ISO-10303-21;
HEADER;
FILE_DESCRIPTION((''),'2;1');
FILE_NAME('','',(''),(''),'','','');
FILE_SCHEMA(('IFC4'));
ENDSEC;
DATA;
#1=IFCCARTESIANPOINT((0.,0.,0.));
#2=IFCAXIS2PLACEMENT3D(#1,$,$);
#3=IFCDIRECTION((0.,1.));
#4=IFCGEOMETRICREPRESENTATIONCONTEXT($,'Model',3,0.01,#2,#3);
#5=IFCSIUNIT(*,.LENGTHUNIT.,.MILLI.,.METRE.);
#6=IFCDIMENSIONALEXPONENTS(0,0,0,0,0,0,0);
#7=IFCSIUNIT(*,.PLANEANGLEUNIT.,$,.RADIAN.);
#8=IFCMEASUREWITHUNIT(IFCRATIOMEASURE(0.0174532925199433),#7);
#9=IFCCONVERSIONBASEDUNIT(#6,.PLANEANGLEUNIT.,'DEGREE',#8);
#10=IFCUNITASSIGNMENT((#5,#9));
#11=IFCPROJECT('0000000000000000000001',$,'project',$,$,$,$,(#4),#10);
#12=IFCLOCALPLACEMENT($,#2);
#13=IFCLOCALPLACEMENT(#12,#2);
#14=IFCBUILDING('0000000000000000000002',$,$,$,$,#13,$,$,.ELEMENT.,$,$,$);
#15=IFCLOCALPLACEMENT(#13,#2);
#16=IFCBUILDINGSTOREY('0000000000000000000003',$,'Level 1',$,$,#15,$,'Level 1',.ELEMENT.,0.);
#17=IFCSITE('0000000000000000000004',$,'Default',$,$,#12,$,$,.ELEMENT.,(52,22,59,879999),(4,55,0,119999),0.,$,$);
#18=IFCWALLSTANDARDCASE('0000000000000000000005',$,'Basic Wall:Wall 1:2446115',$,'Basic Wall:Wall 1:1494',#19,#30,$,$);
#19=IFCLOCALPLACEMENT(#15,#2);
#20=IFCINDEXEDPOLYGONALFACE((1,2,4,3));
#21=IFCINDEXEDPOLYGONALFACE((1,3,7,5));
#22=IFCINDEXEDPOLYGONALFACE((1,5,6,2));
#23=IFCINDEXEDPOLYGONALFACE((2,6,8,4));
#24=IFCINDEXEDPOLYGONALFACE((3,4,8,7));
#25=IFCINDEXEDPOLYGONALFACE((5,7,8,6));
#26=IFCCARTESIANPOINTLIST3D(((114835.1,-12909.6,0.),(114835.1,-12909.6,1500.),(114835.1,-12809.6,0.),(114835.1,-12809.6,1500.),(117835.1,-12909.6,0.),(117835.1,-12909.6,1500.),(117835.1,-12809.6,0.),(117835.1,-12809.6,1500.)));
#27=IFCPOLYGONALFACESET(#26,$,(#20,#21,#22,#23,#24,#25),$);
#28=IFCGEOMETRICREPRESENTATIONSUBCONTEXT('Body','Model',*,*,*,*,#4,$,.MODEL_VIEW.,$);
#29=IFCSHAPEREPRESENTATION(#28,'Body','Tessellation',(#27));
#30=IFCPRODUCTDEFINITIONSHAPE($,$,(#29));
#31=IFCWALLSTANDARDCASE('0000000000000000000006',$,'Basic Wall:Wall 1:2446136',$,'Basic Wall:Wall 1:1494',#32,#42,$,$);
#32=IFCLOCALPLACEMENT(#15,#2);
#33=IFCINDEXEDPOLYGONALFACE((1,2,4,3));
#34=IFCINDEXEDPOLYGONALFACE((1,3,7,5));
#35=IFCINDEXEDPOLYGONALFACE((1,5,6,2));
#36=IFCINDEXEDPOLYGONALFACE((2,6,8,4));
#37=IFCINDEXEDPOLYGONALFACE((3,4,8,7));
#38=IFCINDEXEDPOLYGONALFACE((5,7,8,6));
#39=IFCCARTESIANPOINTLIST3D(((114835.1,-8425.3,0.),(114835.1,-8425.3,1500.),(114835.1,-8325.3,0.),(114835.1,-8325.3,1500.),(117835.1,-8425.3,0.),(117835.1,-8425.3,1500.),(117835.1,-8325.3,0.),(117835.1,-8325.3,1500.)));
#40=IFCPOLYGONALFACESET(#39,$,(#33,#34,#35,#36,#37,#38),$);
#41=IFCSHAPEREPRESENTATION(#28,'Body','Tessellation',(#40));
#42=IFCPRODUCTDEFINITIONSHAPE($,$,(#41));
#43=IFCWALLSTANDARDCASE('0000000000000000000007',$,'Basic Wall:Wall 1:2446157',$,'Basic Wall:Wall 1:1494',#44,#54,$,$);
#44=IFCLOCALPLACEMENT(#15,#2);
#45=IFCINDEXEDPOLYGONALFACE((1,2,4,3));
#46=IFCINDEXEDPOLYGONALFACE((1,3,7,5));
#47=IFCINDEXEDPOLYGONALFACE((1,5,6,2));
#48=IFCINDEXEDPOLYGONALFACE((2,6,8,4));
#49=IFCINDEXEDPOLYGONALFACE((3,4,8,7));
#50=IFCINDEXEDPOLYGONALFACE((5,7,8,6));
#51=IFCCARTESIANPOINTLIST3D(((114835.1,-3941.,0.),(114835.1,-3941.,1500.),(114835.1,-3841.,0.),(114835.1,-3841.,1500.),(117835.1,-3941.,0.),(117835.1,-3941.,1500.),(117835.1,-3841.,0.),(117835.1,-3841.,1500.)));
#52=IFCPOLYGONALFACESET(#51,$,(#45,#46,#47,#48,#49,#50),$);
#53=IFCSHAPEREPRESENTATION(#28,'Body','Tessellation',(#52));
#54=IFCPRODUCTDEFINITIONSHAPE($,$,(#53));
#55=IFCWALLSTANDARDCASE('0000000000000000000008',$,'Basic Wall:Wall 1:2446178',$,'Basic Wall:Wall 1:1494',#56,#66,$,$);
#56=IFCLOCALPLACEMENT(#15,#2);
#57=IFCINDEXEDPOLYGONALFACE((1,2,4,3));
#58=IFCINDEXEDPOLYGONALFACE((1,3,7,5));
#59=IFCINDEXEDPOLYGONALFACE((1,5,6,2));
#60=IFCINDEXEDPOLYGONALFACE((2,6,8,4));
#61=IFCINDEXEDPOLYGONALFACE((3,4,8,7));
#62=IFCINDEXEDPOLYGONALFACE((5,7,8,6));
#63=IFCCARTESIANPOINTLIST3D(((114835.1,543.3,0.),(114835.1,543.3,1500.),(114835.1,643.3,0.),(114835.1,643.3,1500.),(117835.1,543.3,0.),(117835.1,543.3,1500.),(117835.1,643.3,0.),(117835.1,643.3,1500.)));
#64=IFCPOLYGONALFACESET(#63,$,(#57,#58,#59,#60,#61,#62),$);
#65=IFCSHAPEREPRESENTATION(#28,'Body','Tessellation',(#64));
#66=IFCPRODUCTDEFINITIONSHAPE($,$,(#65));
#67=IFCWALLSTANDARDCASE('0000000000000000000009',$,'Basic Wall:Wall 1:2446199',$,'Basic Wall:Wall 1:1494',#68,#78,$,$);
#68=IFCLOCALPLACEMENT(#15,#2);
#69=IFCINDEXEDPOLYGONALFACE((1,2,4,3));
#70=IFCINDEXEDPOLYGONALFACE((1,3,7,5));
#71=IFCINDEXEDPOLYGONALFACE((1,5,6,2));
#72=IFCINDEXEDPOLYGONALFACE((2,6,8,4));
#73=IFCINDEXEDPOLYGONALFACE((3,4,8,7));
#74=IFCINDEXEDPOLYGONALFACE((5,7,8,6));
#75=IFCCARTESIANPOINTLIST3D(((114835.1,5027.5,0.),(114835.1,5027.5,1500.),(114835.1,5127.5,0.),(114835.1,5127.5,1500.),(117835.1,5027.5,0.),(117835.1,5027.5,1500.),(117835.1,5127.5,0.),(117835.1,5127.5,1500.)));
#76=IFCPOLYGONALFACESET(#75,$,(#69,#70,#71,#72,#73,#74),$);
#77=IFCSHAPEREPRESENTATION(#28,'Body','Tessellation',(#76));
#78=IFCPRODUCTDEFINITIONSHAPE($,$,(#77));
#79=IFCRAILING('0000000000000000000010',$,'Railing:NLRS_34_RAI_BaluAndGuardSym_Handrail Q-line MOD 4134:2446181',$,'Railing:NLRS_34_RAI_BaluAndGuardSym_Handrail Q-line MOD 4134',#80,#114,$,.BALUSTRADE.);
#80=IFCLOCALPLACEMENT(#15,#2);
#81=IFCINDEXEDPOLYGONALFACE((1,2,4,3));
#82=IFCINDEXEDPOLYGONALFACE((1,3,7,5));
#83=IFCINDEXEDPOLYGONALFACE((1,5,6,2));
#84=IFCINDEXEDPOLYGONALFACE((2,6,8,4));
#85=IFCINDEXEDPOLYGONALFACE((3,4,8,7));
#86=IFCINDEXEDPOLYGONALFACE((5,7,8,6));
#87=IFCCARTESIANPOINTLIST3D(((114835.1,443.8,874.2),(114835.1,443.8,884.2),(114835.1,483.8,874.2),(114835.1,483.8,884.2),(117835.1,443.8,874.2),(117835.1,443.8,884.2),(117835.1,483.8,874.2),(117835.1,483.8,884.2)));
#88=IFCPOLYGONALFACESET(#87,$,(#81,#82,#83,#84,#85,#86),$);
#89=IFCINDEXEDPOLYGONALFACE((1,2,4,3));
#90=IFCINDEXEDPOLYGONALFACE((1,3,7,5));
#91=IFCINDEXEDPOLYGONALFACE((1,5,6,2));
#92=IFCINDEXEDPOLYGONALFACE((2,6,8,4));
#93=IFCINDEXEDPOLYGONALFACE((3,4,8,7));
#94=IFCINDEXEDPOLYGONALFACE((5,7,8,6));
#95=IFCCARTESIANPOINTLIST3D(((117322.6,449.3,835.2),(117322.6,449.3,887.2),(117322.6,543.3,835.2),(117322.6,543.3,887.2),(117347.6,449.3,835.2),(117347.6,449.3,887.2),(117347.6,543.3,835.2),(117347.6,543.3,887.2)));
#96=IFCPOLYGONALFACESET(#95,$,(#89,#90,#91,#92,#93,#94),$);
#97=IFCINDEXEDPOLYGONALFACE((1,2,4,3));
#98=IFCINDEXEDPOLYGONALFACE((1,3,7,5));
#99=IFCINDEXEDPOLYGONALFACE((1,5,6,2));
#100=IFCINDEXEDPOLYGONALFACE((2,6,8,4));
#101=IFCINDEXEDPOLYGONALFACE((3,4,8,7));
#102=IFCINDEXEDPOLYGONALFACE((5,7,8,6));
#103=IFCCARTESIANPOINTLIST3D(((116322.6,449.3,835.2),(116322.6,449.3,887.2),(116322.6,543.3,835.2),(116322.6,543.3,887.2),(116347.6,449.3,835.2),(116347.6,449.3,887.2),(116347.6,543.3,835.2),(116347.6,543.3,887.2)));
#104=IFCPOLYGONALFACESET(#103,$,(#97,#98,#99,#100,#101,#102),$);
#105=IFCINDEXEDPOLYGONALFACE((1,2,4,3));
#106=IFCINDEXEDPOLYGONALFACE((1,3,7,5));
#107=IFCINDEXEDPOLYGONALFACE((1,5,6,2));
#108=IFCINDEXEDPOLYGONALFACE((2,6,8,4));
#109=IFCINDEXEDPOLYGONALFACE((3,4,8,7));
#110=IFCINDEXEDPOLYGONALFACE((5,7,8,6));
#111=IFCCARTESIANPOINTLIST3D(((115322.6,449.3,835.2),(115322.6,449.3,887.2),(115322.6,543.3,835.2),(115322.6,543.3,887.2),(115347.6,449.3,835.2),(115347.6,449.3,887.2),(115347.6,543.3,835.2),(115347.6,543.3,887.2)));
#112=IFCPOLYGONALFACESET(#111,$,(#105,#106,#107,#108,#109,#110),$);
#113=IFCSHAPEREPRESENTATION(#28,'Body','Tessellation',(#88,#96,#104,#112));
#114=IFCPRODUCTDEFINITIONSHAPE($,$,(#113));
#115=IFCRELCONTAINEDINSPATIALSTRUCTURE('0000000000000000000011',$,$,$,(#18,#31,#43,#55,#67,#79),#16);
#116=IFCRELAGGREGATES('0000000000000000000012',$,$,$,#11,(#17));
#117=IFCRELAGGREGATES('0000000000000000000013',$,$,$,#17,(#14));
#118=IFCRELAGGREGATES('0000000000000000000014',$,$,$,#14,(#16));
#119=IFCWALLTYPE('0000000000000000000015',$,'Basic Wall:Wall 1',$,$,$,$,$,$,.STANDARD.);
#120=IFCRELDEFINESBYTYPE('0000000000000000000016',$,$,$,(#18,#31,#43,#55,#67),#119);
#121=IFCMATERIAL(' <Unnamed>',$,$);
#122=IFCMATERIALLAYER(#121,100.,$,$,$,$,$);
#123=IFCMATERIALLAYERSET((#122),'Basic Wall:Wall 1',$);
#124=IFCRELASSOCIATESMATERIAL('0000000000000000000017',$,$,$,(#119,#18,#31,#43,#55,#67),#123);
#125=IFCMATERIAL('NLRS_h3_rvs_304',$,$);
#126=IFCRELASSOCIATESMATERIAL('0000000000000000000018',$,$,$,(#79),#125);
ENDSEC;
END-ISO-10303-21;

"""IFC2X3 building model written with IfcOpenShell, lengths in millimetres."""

from ifc_helpers import new_model, entity, si_unit, converted_unit, direction, frame, frame_2d, origin, place, context, subcontext, project, spatial, rectangle, extrude, material, layer, layer_set, layer_usage, type_object, element, save


model = new_model("IFC2X3")

# Units and contexts
model_context = context("Model", 3, precision=0.01, world=origin(), true_north=direction((0.0, 1.0)))
body_context = subcontext(model_context, "Body", "Model", "MODEL_VIEW")
ifc_project = project(units=[si_unit("LENGTHUNIT", "METRE", prefix="MILLI"), converted_unit("PLANEANGLEUNIT", "DEGREE", entity("IfcRatioMeasure", 0.0174532925199433), si_unit("PLANEANGLEUNIT", "RADIAN"), dimensions=[0, 0, 0, 0, 0, 0, 0])], contexts=[model_context])

# Site, building, storey
site_placement = place(None, origin())
site = spatial("IfcSite", under=ifc_project, at=site_placement, Name="Default", CompositionType="ELEMENT", RefLatitude=(52, 22, 59, 879999), RefLongitude=(4, 55, 0, 119999), RefElevation=0.0)
building_placement = place(site_placement, origin())
building = spatial("IfcBuilding", under=site, at=building_placement, CompositionType="ELEMENT")
storey_placement = place(building_placement, origin())
storey = spatial("IfcBuildingStorey", under=building, at=storey_placement, Name="Level 1", LongName="Level 1", CompositionType="ELEMENT", Elevation=0.0)

# Walls
ifc_material_1 = material(Name=" <Unnamed>")
ifc_layer = layer(ifc_material_1, 100.0)
ifc_layer_set = layer_set([ifc_layer], Name="Basic Wall:Wall 1")
ifc_layer_usage_1 = layer_usage(ifc_layer_set, "AXIS2", "NEGATIVE", 50.0)
wall_type = type_object("IfcWallType", Name="Basic Wall:Wall 1", PredefinedType="STANDARD", material=ifc_layer_set)
wall_1_placement = place(storey_placement, frame((114835.1, -12859.6, 0.0)))
element("IfcWallStandardCase", 1, at=wall_1_placement, inside=storey, type_object=wall_type, material=ifc_layer_usage_1, Name="Basic Wall:Wall 1:2446115", ObjectType="Basic Wall:Wall 1:1494", context=body_context, shape_type="SweptSolid", body=[
    extrude(rectangle(XDim=3000.0, YDim=100.0, at=frame_2d((1500.0, 0.0), x_axis=(-1.0, 0.0))), origin(), (0.0, 0.0, 1.0), 1500.0),
])
ifc_layer_usage_2 = layer_usage(ifc_layer_set, "AXIS2", "NEGATIVE", 50.0)
wall_2_placement = place(storey_placement, frame((114835.1, -8375.3, 0.0)))
element("IfcWallStandardCase", 2, at=wall_2_placement, inside=storey, type_object=wall_type, material=ifc_layer_usage_2, Name="Basic Wall:Wall 1:2446136", ObjectType="Basic Wall:Wall 1:1494", context=body_context, shape_type="SweptSolid", body=[
    extrude(rectangle(XDim=3000.0, YDim=100.0, at=frame_2d((1500.0, 0.0), x_axis=(-1.0, 0.0))), origin(), (0.0, 0.0, 1.0), 1500.0),
])
ifc_layer_usage_3 = layer_usage(ifc_layer_set, "AXIS2", "NEGATIVE", 50.0)
wall_3_placement = place(storey_placement, frame((114835.1, -3891.0, 0.0)))
element("IfcWallStandardCase", 3, at=wall_3_placement, inside=storey, type_object=wall_type, material=ifc_layer_usage_3, Name="Basic Wall:Wall 1:2446157", ObjectType="Basic Wall:Wall 1:1494", context=body_context, shape_type="SweptSolid", body=[
    extrude(rectangle(XDim=3000.0, YDim=100.0, at=frame_2d((1500.0, 0.0), x_axis=(-1.0, 0.0))), origin(), (0.0, 0.0, 1.0), 1500.0),
])
ifc_layer_usage_4 = layer_usage(ifc_layer_set, "AXIS2", "NEGATIVE", 50.0)
wall_4_placement = place(storey_placement, frame((114835.1, 593.3, 0.0)))
element("IfcWallStandardCase", 4, at=wall_4_placement, inside=storey, type_object=wall_type, material=ifc_layer_usage_4, Name="Basic Wall:Wall 1:2446178", ObjectType="Basic Wall:Wall 1:1494", context=body_context, shape_type="SweptSolid", body=[
    extrude(rectangle(XDim=3000.0, YDim=100.0, at=frame_2d((1500.0, 0.0), x_axis=(-1.0, 0.0))), origin(), (0.0, 0.0, 1.0), 1500.0),
])
ifc_layer_usage_5 = layer_usage(ifc_layer_set, "AXIS2", "NEGATIVE", 50.0)
wall_5_placement = place(storey_placement, frame((114835.1, 5077.5, 0.0)))
element("IfcWallStandardCase", 5, at=wall_5_placement, inside=storey, type_object=wall_type, material=ifc_layer_usage_5, Name="Basic Wall:Wall 1:2446199", ObjectType="Basic Wall:Wall 1:1494", context=body_context, shape_type="SweptSolid", body=[
    extrude(rectangle(XDim=3000.0, YDim=100.0, at=frame_2d((1500.0, 0.0), x_axis=(-1.0, 0.0))), origin(), (0.0, 0.0, 1.0), 1500.0),
])

# Railing
ifc_material_2 = material(Name="NLRS_h3_rvs_304")
railing_1_placement = place(storey_placement, origin())
element("IfcRailing", 6, at=railing_1_placement, inside=storey, material=ifc_material_2, Name="Railing:NLRS_34_RAI_BaluAndGuardSym_Handrail Q-line MOD 4134:2446181", ObjectType="Railing:NLRS_34_RAI_BaluAndGuardSym_Handrail Q-line MOD 4134", PredefinedType="BALUSTRADE", context=body_context, shape_type="SweptSolid", body=[
    extrude(rectangle(XDim=3000.0, YDim=40.0, at=frame_2d((0.0, 0.0), x_axis=(1.0, 0.0))), frame((116335.1, 463.8, 874.2), z_axis=(0.0, 0.0, 1.0), x_axis=(-1.0, 0.0, 0.0)), (0.0, 0.0, 1.0), 10.0),
    extrude(rectangle(XDim=94.0, YDim=25.0, at=frame_2d((0.0, 0.0), x_axis=(1.0, 0.0))), frame((117335.1, 496.3, 835.2), z_axis=(0.0, 0.0, 1.0), x_axis=(0.0, 1.0, 0.0)), (0.0, 0.0, 1.0), 52.0),
    extrude(rectangle(XDim=94.0, YDim=25.0, at=frame_2d((0.0, 0.0), x_axis=(1.0, 0.0))), frame((116335.1, 496.3, 835.2), z_axis=(0.0, 0.0, 1.0), x_axis=(0.0, 1.0, 0.0)), (0.0, 0.0, 1.0), 52.0),
    extrude(rectangle(XDim=94.0, YDim=25.0, at=frame_2d((0.0, 0.0), x_axis=(1.0, 0.0))), frame((115335.1, 496.3, 835.2), z_axis=(0.0, 0.0, 1.0), x_axis=(0.0, 1.0, 0.0)), (0.0, 0.0, 1.0), 52.0),
])

save(model, "model.ifc")
